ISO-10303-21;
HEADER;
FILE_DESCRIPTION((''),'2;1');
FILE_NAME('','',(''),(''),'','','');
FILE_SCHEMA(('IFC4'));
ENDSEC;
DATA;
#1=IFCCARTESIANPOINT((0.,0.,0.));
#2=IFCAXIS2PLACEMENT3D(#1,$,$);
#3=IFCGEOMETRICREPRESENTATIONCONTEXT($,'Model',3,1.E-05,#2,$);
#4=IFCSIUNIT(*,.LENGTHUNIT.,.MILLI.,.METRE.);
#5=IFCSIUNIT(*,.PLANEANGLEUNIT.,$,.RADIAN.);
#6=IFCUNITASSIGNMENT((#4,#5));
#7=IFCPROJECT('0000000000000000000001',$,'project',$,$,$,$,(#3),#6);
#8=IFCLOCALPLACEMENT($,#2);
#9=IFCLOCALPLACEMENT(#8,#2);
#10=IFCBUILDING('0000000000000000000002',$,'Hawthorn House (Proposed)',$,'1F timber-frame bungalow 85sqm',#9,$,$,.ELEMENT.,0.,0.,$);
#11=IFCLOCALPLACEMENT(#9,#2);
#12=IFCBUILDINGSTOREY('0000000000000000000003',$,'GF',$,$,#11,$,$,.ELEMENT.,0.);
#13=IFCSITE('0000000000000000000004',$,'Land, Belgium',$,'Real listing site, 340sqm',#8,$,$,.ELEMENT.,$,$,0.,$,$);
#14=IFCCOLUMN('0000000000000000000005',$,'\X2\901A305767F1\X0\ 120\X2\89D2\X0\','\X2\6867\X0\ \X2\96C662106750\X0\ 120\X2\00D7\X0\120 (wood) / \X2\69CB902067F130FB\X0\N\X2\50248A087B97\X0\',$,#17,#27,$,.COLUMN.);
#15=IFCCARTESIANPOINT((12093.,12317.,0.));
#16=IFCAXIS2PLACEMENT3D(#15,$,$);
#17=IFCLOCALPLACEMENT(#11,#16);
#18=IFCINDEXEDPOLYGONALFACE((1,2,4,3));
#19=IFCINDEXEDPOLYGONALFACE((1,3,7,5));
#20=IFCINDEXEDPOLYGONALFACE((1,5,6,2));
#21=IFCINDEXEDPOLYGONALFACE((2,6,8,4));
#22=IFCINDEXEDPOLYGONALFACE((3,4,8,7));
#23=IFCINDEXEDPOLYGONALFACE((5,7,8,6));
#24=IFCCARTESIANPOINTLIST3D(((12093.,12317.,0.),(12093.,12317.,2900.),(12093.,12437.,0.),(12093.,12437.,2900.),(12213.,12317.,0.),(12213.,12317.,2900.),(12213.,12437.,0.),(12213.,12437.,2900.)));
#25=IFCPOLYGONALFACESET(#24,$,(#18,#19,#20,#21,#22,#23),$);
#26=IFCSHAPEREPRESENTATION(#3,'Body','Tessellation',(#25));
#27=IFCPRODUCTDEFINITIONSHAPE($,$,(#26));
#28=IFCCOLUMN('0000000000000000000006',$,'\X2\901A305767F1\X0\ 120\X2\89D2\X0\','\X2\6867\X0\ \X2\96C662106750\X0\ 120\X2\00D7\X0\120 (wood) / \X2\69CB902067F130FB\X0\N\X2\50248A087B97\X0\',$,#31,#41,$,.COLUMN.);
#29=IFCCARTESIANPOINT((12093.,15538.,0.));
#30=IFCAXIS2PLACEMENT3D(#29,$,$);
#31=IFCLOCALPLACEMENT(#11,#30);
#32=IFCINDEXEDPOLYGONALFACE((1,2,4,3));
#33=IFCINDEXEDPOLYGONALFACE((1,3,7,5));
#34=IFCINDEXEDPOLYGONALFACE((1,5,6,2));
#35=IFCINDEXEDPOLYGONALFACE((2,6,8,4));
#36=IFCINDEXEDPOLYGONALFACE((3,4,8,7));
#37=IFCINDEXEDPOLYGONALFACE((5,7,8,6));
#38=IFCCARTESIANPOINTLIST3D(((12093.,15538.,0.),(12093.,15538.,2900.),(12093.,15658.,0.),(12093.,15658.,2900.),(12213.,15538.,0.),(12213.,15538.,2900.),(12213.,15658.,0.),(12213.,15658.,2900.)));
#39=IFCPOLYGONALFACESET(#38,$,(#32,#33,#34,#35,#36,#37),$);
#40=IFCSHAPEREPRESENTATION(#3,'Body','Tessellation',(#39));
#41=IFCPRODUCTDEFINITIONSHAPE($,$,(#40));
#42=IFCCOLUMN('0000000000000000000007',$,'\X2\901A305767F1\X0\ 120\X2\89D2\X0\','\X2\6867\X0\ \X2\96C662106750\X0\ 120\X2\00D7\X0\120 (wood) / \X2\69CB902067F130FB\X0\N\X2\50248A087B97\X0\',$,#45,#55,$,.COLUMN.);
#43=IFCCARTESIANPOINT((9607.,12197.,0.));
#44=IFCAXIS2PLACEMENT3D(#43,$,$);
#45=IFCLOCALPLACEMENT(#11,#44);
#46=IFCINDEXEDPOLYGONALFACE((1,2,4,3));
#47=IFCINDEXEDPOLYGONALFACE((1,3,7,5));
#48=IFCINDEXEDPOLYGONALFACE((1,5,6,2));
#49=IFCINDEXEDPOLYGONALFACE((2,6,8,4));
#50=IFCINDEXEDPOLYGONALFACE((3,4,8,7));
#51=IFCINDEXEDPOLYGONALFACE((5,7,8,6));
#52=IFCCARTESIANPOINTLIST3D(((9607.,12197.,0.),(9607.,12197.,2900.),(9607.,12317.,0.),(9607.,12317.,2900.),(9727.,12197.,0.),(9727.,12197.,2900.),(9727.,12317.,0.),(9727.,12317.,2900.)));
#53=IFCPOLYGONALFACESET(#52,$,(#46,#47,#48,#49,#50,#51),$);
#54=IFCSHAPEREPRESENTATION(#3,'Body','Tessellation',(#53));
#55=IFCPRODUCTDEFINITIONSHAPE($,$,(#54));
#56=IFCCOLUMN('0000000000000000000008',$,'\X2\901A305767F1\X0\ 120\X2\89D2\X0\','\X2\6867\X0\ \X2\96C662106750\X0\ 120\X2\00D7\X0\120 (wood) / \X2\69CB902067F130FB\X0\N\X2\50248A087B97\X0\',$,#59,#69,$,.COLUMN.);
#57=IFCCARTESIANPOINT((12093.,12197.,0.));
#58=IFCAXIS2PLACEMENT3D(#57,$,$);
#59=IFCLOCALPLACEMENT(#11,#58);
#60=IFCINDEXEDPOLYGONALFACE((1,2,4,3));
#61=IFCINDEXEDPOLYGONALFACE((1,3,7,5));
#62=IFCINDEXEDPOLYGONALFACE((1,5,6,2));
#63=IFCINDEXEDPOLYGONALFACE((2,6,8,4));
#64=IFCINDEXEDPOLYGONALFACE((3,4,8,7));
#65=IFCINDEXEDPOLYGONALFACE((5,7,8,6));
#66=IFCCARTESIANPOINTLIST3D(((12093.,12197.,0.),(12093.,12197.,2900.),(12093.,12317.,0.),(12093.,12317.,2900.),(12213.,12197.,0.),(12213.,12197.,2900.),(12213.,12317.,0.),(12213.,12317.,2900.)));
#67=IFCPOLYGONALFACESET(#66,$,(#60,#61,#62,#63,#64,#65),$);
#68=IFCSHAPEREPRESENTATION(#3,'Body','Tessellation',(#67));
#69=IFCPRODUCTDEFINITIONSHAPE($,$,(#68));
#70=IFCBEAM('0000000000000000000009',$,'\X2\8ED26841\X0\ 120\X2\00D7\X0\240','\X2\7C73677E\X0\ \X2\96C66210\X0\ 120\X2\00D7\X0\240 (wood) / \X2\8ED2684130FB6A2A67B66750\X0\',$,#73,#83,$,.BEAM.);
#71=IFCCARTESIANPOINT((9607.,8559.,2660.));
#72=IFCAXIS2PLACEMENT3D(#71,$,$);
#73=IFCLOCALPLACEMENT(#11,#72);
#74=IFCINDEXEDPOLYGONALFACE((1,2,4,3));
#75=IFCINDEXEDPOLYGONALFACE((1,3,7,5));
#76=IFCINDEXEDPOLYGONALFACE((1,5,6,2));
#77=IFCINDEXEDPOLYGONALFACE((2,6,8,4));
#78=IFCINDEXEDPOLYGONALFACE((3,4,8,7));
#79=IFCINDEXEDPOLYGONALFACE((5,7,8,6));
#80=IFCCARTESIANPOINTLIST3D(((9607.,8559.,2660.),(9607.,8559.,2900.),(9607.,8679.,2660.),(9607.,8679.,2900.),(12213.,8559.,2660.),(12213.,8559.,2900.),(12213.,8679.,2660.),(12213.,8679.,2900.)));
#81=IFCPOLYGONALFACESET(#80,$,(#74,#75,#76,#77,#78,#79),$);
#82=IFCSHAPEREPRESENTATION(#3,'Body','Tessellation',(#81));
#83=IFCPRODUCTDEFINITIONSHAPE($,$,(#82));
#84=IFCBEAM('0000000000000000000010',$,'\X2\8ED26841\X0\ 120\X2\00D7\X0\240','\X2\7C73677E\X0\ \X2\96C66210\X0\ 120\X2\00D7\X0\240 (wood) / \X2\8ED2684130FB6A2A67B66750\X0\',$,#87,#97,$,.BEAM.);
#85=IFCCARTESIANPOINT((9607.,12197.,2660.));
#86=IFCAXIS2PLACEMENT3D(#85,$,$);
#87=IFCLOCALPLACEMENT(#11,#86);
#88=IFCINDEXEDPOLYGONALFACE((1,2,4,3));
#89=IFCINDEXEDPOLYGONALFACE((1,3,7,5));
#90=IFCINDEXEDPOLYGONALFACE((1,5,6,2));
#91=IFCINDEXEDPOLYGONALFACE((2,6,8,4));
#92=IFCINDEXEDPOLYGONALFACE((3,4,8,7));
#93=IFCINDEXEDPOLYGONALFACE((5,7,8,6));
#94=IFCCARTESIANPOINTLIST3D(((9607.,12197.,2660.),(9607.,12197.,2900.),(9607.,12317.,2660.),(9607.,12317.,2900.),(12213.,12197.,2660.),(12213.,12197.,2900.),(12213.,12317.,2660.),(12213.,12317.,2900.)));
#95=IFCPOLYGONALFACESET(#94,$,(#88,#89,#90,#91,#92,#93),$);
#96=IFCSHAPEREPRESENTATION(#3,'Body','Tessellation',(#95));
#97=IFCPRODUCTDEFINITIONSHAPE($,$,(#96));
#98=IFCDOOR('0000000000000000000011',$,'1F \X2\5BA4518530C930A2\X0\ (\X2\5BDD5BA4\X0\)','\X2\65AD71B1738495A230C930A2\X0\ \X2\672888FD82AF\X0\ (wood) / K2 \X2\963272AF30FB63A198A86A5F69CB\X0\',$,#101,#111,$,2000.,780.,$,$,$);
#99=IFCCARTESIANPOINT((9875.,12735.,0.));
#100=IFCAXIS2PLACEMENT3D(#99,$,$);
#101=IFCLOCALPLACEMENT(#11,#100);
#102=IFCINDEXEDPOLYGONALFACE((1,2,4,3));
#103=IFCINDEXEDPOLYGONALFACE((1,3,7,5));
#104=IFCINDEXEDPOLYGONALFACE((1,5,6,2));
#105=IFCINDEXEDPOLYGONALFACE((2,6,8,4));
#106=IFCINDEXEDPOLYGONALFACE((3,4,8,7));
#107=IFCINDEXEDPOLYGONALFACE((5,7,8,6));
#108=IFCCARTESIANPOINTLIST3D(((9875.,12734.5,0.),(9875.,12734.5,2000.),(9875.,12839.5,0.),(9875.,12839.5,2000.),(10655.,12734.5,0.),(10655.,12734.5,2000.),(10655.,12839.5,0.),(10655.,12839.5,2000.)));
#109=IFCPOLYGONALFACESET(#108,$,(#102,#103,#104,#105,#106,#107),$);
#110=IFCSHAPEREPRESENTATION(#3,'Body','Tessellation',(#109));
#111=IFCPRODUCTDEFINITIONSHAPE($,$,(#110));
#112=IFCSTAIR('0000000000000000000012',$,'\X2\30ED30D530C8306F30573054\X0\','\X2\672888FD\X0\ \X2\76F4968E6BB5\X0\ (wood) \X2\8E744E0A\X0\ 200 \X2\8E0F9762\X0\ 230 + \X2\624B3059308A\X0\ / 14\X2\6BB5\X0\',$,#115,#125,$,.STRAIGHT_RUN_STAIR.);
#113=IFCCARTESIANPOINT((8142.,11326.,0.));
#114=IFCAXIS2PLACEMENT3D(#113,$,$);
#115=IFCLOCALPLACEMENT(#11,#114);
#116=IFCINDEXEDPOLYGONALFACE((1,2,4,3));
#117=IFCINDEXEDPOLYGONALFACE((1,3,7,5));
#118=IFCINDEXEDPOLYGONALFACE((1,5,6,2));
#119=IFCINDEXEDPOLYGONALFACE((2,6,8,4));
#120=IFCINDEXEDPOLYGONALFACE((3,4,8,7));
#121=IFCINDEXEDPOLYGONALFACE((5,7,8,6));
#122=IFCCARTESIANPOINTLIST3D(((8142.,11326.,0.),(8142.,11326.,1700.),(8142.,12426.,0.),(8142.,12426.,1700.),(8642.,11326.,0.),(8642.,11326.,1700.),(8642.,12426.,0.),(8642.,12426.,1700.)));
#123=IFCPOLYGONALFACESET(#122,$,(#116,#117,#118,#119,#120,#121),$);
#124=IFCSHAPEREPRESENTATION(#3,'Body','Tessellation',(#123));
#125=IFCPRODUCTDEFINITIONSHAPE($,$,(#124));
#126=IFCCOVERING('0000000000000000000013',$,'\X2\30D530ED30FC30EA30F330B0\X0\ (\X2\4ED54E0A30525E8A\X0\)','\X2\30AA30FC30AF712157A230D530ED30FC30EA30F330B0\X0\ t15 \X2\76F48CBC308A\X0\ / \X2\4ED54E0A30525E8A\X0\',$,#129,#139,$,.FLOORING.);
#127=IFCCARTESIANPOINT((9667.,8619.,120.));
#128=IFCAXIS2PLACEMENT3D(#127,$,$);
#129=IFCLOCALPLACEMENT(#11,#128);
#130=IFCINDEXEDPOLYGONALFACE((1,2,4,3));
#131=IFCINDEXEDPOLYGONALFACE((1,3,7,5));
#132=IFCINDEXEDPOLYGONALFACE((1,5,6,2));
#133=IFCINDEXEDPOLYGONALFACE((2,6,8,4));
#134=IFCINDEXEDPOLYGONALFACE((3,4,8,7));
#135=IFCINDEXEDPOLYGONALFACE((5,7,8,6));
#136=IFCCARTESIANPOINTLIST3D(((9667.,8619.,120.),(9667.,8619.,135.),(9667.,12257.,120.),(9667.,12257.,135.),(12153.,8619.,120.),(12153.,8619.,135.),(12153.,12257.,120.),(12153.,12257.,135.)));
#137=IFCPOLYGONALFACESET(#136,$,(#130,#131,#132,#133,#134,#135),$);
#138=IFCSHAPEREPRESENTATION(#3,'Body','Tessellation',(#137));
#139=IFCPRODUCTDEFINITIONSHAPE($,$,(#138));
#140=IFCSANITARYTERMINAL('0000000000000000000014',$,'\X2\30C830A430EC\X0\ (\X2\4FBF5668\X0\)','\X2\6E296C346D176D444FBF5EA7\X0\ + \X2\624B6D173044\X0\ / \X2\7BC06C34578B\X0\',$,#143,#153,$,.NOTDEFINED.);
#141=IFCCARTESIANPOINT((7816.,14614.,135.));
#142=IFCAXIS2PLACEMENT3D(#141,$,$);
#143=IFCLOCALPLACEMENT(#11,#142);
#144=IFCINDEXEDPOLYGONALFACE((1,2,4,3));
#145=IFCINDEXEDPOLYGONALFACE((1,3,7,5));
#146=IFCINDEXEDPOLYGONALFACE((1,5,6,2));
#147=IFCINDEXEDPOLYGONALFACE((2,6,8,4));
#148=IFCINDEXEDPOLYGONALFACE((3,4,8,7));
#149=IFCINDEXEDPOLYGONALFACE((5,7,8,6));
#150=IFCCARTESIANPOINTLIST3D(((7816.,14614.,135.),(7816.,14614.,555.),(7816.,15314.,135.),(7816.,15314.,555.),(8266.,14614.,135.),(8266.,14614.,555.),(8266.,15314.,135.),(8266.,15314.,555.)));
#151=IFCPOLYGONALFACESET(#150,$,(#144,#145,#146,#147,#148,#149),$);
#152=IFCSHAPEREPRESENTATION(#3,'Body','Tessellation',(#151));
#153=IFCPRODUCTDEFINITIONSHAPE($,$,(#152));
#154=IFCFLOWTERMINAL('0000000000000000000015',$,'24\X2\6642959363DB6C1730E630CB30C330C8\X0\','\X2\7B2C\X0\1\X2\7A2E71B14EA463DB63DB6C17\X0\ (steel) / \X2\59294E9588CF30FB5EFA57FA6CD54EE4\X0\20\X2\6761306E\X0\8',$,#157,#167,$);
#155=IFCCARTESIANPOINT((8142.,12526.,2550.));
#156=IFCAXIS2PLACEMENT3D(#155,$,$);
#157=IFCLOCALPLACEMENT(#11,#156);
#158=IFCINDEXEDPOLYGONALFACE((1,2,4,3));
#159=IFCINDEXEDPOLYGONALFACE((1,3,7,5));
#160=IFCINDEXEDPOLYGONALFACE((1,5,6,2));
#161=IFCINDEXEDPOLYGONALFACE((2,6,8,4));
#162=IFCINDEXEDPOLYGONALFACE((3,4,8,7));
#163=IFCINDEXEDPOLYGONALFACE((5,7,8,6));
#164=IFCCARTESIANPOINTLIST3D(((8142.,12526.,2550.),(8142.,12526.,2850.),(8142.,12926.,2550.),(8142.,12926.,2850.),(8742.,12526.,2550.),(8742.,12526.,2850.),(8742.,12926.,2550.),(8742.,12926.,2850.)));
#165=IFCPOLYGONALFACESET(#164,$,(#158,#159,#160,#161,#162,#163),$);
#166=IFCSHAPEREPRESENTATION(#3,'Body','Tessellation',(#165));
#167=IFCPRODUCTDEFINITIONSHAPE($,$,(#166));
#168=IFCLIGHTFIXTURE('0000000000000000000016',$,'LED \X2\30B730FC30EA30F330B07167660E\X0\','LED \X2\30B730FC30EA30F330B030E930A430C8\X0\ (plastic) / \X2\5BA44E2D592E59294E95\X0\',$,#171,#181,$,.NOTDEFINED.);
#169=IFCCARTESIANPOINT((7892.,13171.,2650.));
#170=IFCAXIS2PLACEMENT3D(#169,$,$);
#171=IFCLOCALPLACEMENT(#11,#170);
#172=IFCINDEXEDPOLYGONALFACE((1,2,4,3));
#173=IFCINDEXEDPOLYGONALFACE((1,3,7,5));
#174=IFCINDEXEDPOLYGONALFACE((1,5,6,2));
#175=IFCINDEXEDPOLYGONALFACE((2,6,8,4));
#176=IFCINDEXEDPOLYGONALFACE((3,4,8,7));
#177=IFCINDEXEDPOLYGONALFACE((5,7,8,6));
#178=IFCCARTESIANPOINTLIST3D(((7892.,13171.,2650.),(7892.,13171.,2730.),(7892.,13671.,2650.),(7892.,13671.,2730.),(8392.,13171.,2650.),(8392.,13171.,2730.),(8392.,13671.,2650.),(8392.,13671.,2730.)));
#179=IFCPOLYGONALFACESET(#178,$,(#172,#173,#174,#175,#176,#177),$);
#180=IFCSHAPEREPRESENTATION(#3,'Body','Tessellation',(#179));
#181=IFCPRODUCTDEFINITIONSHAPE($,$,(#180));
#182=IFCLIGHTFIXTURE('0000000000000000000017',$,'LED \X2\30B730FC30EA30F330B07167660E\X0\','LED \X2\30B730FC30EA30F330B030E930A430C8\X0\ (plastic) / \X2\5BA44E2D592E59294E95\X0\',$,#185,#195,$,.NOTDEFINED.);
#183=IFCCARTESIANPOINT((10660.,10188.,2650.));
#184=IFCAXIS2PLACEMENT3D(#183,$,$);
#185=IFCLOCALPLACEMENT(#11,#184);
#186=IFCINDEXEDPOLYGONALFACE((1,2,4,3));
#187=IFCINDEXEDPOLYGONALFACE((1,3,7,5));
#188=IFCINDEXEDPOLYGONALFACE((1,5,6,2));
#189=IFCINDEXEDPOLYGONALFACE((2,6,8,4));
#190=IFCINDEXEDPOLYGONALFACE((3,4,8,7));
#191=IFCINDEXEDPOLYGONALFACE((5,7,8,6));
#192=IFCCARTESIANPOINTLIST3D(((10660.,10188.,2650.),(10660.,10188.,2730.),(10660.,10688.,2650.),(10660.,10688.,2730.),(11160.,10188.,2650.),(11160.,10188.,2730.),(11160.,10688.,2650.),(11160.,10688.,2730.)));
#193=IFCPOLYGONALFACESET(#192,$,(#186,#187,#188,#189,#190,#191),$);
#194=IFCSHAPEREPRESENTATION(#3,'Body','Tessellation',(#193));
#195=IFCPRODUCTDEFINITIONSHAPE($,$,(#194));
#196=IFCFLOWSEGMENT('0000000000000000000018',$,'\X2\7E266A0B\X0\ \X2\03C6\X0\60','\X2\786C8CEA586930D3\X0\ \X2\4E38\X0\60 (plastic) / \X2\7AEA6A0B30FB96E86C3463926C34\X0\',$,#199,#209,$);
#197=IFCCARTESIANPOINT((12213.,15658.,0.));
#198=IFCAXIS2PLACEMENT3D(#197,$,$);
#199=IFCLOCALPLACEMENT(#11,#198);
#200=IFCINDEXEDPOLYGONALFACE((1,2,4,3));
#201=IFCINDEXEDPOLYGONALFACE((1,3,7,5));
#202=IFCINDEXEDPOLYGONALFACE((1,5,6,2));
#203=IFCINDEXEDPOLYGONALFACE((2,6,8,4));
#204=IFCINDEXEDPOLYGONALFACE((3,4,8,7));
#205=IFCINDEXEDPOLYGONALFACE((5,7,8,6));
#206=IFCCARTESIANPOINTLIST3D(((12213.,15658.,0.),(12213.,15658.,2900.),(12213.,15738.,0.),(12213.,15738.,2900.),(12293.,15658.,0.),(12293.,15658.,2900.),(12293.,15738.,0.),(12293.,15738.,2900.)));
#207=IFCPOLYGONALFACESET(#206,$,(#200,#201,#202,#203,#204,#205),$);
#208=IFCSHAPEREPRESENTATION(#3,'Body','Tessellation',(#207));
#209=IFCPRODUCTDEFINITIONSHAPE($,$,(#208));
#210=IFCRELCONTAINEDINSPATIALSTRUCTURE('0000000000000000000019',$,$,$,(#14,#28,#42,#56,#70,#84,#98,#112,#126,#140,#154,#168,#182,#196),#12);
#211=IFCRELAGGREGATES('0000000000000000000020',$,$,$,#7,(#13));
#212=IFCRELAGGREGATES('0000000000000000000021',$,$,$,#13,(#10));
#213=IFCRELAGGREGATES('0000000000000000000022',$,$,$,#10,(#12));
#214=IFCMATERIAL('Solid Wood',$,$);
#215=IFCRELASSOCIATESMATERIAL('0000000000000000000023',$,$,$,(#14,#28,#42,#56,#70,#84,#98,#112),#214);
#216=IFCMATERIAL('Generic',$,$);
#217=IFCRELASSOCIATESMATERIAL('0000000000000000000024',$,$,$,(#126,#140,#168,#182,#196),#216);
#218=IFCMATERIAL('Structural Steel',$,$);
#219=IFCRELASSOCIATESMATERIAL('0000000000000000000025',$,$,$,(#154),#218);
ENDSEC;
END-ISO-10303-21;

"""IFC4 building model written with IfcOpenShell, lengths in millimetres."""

from ifc_helpers import new_model, si_unit, frame, frame_2d, origin, place, context, project, spatial, rectangle, extrude, material, element, save


model = new_model("IFC4")

# Units and contexts
model_context = context("Model", 3, precision=1e-05, world=origin())
ifc_project = project(units=[si_unit("LENGTHUNIT", "METRE", prefix="MILLI"), si_unit("PLANEANGLEUNIT", "RADIAN")], contexts=[model_context])

# Site, building, storey
site_placement = place(None, origin())
site = spatial("IfcSite", under=ifc_project, at=site_placement, Name="Land, Belgium", ObjectType="Real listing site, 340sqm", CompositionType="ELEMENT", RefElevation=0.0)
building_placement = place(site_placement, origin())
building = spatial("IfcBuilding", under=site, at=building_placement, Name="Hawthorn House (Proposed)", ObjectType="1F timber-frame bungalow 85sqm", CompositionType="ELEMENT", ElevationOfRefHeight=0.0, ElevationOfTerrain=0.0)
storey_placement = place(building_placement, origin())
storey = spatial("IfcBuildingStorey", under=building, at=storey_placement, Name="GF", CompositionType="ELEMENT", Elevation=0.0)

# Columns
ifc_material_1 = material(Name="Solid Wood")
column_1_placement = place(storey_placement, frame((12093.0, 12317.0, 0.0)))
element("IfcColumn", 1, at=column_1_placement, inside=storey, material=ifc_material_1, Name="通し柱 120角", Description="桧 集成材 120×120 (wood) / 構造柱・N値計算", PredefinedType="COLUMN", context=model_context, shape_type="SweptSolid", body=[
    extrude(rectangle(XDim=120.0, YDim=120.0, at=frame_2d((60.0, 60.0))), frame((12093.0, 12317.0, 0.0)), (0.0, 0.0, 1.0), 2900.0),
])
column_2_placement = place(storey_placement, frame((12093.0, 15538.0, 0.0)))
element("IfcColumn", 2, at=column_2_placement, inside=storey, material=ifc_material_1, Name="通し柱 120角", Description="桧 集成材 120×120 (wood) / 構造柱・N値計算", PredefinedType="COLUMN", context=model_context, shape_type="SweptSolid", body=[
    extrude(rectangle(XDim=120.0, YDim=120.0, at=frame_2d((60.0, 60.0))), frame((12093.0, 15538.0, 0.0)), (0.0, 0.0, 1.0), 2900.0),
])
column_3_placement = place(storey_placement, frame((9607.0, 12197.0, 0.0)))
element("IfcColumn", 3, at=column_3_placement, inside=storey, material=ifc_material_1, Name="通し柱 120角", Description="桧 集成材 120×120 (wood) / 構造柱・N値計算", PredefinedType="COLUMN", context=model_context, shape_type="SweptSolid", body=[
    extrude(rectangle(XDim=120.0, YDim=120.0, at=frame_2d((60.0, 60.0))), frame((9607.0, 12197.0, 0.0)), (0.0, 0.0, 1.0), 2900.0),
])
column_4_placement = place(storey_placement, frame((12093.0, 12197.0, 0.0)))
element("IfcColumn", 4, at=column_4_placement, inside=storey, material=ifc_material_1, Name="通し柱 120角", Description="桧 集成材 120×120 (wood) / 構造柱・N値計算", PredefinedType="COLUMN", context=model_context, shape_type="SweptSolid", body=[
    extrude(rectangle(XDim=120.0, YDim=120.0, at=frame_2d((60.0, 60.0))), frame((12093.0, 12197.0, 0.0)), (0.0, 0.0, 1.0), 2900.0),
])

# Beams
beam_1_placement = place(storey_placement, frame((9607.0, 8559.0, 2660.0)))
element("IfcBeam", 5, at=beam_1_placement, inside=storey, material=ifc_material_1, Name="軒桁 120×240", Description="米松 集成 120×240 (wood) / 軒桁・横架材", PredefinedType="BEAM", context=model_context, shape_type="SweptSolid", body=[
    extrude(rectangle(XDim=2606.0, YDim=120.0, at=frame_2d((1303.0, 60.0))), frame((9607.0, 8559.0, 2660.0)), (0.0, 0.0, 1.0), 240.0),
])
beam_2_placement = place(storey_placement, frame((9607.0, 12197.0, 2660.0)))
element("IfcBeam", 6, at=beam_2_placement, inside=storey, material=ifc_material_1, Name="軒桁 120×240", Description="米松 集成 120×240 (wood) / 軒桁・横架材", PredefinedType="BEAM", context=model_context, shape_type="SweptSolid", body=[
    extrude(rectangle(XDim=2606.0, YDim=120.0, at=frame_2d((1303.0, 60.0))), frame((9607.0, 12197.0, 2660.0)), (0.0, 0.0, 1.0), 240.0),
])

# Door
door_placement = place(storey_placement, frame((9875.0, 12735.0, 0.0)))
element("IfcDoor", 7, at=door_placement, inside=storey, material=ifc_material_1, Name="1F 室内ドア (寝室)", Description="断熱玄関ドア 木製芯 (wood) / K2 防犯・採風機構", OverallHeight=2000.0, OverallWidth=780.0, context=model_context, shape_type="SweptSolid", body=[
    extrude(rectangle(XDim=780.0, YDim=105.0, at=frame_2d((390.0, 52.0))), frame((9875.0, 12735.0, 0.0)), (0.0, 0.0, 1.0), 2000.0),
])

# Stair
stair_placement = place(storey_placement, frame((8142.0, 11326.0, 0.0)))
element("IfcStair", 8, at=stair_placement, inside=storey, material=ifc_material_1, Name="ロフトはしご", Description="木製 直階段 (wood) 蹴上 200 踏面 230 + 手すり / 14段", PredefinedType="STRAIGHT_RUN_STAIR", context=model_context, shape_type="SweptSolid", body=[
    extrude(rectangle(XDim=500.0, YDim=1100.0, at=frame_2d((250.0, 550.0))), frame((8142.0, 11326.0, 0.0)), (0.0, 0.0, 1.0), 1700.0),
])

# Covering
ifc_material_2 = material(Name="Generic")
covering_placement = place(storey_placement, frame((9667.0, 8619.0, 120.0)))
element("IfcCovering", 9, at=covering_placement, inside=storey, material=ifc_material_2, Name="フローリング (仕上げ床)", Description="オーク無垢フローリング t15 直貼り / 仕上げ床", PredefinedType="FLOORING", context=model_context, shape_type="SweptSolid", body=[
    extrude(rectangle(XDim=2486.0, YDim=3638.0, at=frame_2d((1243.0, 1819.0))), frame((9667.0, 8619.0, 120.0)), (0.0, 0.0, 1.0), 15.0),
])

# Sanitary terminal
sanitary_terminal_placement = place(storey_placement, frame((7816.0, 14614.0, 135.0)))
element("IfcSanitaryTerminal", 10, at=sanitary_terminal_placement, inside=storey, material=ifc_material_2, Name="トイレ (便器)", Description="温水洗浄便座 + 手洗い / 節水型", PredefinedType="NOTDEFINED", context=model_context, shape_type="SweptSolid", body=[
    extrude(rectangle(XDim=450.0, YDim=700.0, at=frame_2d((225.0, 350.0))), frame((7816.0, 14614.0, 135.0)), (0.0, 0.0, 1.0), 420.0),
])

# Flow terminal
ifc_material_3 = material(Name="Structural Steel")
flow_terminal_placement = place(storey_placement, frame((8142.0, 12526.0, 2550.0)))
element("IfcFlowTerminal", 11, at=flow_terminal_placement, inside=storey, material=ifc_material_3, Name="24時間換気ユニット", Description="第1種熱交換換気 (steel) / 天井裏・建基法令20条の8", context=model_context, shape_type="SweptSolid", body=[
    extrude(rectangle(XDim=600.0, YDim=400.0, at=frame_2d((300.0, 200.0))), frame((8142.0, 12526.0, 2550.0)), (0.0, 0.0, 1.0), 300.0),
])

# Light fixtures
light_fixture_1_placement = place(storey_placement, frame((7892.0, 13171.0, 2650.0)))
element("IfcLightFixture", 12, at=light_fixture_1_placement, inside=storey, material=ifc_material_2, Name="LED シーリング照明", Description="LED シーリングライト (plastic) / 室中央天井", PredefinedType="NOTDEFINED", context=model_context, shape_type="SweptSolid", body=[
    extrude(rectangle(XDim=500.0, YDim=500.0, at=frame_2d((250.0, 250.0))), frame((7892.0, 13171.0, 2650.0)), (0.0, 0.0, 1.0), 80.0),
])
light_fixture_2_placement = place(storey_placement, frame((10660.0, 10188.0, 2650.0)))
element("IfcLightFixture", 13, at=light_fixture_2_placement, inside=storey, material=ifc_material_2, Name="LED シーリング照明", Description="LED シーリングライト (plastic) / 室中央天井", PredefinedType="NOTDEFINED", context=model_context, shape_type="SweptSolid", body=[
    extrude(rectangle(XDim=500.0, YDim=500.0, at=frame_2d((250.0, 250.0))), frame((10660.0, 10188.0, 2650.0)), (0.0, 0.0, 1.0), 80.0),
])

# Flow segment
flow_segment_placement = place(storey_placement, frame((12213.0, 15658.0, 0.0)))
element("IfcFlowSegment", 14, at=flow_segment_placement, inside=storey, material=ifc_material_2, Name="縦樋 φ60", Description="硬質塩ビ 丸60 (plastic) / 竪樋・雨水排水", context=model_context, shape_type="SweptSolid", body=[
    extrude(rectangle(XDim=80.0, YDim=80.0, at=frame_2d((40.0, 40.0))), frame((12213.0, 15658.0, 0.0)), (0.0, 0.0, 1.0), 2900.0),
])

save(model, "model.ifc")
